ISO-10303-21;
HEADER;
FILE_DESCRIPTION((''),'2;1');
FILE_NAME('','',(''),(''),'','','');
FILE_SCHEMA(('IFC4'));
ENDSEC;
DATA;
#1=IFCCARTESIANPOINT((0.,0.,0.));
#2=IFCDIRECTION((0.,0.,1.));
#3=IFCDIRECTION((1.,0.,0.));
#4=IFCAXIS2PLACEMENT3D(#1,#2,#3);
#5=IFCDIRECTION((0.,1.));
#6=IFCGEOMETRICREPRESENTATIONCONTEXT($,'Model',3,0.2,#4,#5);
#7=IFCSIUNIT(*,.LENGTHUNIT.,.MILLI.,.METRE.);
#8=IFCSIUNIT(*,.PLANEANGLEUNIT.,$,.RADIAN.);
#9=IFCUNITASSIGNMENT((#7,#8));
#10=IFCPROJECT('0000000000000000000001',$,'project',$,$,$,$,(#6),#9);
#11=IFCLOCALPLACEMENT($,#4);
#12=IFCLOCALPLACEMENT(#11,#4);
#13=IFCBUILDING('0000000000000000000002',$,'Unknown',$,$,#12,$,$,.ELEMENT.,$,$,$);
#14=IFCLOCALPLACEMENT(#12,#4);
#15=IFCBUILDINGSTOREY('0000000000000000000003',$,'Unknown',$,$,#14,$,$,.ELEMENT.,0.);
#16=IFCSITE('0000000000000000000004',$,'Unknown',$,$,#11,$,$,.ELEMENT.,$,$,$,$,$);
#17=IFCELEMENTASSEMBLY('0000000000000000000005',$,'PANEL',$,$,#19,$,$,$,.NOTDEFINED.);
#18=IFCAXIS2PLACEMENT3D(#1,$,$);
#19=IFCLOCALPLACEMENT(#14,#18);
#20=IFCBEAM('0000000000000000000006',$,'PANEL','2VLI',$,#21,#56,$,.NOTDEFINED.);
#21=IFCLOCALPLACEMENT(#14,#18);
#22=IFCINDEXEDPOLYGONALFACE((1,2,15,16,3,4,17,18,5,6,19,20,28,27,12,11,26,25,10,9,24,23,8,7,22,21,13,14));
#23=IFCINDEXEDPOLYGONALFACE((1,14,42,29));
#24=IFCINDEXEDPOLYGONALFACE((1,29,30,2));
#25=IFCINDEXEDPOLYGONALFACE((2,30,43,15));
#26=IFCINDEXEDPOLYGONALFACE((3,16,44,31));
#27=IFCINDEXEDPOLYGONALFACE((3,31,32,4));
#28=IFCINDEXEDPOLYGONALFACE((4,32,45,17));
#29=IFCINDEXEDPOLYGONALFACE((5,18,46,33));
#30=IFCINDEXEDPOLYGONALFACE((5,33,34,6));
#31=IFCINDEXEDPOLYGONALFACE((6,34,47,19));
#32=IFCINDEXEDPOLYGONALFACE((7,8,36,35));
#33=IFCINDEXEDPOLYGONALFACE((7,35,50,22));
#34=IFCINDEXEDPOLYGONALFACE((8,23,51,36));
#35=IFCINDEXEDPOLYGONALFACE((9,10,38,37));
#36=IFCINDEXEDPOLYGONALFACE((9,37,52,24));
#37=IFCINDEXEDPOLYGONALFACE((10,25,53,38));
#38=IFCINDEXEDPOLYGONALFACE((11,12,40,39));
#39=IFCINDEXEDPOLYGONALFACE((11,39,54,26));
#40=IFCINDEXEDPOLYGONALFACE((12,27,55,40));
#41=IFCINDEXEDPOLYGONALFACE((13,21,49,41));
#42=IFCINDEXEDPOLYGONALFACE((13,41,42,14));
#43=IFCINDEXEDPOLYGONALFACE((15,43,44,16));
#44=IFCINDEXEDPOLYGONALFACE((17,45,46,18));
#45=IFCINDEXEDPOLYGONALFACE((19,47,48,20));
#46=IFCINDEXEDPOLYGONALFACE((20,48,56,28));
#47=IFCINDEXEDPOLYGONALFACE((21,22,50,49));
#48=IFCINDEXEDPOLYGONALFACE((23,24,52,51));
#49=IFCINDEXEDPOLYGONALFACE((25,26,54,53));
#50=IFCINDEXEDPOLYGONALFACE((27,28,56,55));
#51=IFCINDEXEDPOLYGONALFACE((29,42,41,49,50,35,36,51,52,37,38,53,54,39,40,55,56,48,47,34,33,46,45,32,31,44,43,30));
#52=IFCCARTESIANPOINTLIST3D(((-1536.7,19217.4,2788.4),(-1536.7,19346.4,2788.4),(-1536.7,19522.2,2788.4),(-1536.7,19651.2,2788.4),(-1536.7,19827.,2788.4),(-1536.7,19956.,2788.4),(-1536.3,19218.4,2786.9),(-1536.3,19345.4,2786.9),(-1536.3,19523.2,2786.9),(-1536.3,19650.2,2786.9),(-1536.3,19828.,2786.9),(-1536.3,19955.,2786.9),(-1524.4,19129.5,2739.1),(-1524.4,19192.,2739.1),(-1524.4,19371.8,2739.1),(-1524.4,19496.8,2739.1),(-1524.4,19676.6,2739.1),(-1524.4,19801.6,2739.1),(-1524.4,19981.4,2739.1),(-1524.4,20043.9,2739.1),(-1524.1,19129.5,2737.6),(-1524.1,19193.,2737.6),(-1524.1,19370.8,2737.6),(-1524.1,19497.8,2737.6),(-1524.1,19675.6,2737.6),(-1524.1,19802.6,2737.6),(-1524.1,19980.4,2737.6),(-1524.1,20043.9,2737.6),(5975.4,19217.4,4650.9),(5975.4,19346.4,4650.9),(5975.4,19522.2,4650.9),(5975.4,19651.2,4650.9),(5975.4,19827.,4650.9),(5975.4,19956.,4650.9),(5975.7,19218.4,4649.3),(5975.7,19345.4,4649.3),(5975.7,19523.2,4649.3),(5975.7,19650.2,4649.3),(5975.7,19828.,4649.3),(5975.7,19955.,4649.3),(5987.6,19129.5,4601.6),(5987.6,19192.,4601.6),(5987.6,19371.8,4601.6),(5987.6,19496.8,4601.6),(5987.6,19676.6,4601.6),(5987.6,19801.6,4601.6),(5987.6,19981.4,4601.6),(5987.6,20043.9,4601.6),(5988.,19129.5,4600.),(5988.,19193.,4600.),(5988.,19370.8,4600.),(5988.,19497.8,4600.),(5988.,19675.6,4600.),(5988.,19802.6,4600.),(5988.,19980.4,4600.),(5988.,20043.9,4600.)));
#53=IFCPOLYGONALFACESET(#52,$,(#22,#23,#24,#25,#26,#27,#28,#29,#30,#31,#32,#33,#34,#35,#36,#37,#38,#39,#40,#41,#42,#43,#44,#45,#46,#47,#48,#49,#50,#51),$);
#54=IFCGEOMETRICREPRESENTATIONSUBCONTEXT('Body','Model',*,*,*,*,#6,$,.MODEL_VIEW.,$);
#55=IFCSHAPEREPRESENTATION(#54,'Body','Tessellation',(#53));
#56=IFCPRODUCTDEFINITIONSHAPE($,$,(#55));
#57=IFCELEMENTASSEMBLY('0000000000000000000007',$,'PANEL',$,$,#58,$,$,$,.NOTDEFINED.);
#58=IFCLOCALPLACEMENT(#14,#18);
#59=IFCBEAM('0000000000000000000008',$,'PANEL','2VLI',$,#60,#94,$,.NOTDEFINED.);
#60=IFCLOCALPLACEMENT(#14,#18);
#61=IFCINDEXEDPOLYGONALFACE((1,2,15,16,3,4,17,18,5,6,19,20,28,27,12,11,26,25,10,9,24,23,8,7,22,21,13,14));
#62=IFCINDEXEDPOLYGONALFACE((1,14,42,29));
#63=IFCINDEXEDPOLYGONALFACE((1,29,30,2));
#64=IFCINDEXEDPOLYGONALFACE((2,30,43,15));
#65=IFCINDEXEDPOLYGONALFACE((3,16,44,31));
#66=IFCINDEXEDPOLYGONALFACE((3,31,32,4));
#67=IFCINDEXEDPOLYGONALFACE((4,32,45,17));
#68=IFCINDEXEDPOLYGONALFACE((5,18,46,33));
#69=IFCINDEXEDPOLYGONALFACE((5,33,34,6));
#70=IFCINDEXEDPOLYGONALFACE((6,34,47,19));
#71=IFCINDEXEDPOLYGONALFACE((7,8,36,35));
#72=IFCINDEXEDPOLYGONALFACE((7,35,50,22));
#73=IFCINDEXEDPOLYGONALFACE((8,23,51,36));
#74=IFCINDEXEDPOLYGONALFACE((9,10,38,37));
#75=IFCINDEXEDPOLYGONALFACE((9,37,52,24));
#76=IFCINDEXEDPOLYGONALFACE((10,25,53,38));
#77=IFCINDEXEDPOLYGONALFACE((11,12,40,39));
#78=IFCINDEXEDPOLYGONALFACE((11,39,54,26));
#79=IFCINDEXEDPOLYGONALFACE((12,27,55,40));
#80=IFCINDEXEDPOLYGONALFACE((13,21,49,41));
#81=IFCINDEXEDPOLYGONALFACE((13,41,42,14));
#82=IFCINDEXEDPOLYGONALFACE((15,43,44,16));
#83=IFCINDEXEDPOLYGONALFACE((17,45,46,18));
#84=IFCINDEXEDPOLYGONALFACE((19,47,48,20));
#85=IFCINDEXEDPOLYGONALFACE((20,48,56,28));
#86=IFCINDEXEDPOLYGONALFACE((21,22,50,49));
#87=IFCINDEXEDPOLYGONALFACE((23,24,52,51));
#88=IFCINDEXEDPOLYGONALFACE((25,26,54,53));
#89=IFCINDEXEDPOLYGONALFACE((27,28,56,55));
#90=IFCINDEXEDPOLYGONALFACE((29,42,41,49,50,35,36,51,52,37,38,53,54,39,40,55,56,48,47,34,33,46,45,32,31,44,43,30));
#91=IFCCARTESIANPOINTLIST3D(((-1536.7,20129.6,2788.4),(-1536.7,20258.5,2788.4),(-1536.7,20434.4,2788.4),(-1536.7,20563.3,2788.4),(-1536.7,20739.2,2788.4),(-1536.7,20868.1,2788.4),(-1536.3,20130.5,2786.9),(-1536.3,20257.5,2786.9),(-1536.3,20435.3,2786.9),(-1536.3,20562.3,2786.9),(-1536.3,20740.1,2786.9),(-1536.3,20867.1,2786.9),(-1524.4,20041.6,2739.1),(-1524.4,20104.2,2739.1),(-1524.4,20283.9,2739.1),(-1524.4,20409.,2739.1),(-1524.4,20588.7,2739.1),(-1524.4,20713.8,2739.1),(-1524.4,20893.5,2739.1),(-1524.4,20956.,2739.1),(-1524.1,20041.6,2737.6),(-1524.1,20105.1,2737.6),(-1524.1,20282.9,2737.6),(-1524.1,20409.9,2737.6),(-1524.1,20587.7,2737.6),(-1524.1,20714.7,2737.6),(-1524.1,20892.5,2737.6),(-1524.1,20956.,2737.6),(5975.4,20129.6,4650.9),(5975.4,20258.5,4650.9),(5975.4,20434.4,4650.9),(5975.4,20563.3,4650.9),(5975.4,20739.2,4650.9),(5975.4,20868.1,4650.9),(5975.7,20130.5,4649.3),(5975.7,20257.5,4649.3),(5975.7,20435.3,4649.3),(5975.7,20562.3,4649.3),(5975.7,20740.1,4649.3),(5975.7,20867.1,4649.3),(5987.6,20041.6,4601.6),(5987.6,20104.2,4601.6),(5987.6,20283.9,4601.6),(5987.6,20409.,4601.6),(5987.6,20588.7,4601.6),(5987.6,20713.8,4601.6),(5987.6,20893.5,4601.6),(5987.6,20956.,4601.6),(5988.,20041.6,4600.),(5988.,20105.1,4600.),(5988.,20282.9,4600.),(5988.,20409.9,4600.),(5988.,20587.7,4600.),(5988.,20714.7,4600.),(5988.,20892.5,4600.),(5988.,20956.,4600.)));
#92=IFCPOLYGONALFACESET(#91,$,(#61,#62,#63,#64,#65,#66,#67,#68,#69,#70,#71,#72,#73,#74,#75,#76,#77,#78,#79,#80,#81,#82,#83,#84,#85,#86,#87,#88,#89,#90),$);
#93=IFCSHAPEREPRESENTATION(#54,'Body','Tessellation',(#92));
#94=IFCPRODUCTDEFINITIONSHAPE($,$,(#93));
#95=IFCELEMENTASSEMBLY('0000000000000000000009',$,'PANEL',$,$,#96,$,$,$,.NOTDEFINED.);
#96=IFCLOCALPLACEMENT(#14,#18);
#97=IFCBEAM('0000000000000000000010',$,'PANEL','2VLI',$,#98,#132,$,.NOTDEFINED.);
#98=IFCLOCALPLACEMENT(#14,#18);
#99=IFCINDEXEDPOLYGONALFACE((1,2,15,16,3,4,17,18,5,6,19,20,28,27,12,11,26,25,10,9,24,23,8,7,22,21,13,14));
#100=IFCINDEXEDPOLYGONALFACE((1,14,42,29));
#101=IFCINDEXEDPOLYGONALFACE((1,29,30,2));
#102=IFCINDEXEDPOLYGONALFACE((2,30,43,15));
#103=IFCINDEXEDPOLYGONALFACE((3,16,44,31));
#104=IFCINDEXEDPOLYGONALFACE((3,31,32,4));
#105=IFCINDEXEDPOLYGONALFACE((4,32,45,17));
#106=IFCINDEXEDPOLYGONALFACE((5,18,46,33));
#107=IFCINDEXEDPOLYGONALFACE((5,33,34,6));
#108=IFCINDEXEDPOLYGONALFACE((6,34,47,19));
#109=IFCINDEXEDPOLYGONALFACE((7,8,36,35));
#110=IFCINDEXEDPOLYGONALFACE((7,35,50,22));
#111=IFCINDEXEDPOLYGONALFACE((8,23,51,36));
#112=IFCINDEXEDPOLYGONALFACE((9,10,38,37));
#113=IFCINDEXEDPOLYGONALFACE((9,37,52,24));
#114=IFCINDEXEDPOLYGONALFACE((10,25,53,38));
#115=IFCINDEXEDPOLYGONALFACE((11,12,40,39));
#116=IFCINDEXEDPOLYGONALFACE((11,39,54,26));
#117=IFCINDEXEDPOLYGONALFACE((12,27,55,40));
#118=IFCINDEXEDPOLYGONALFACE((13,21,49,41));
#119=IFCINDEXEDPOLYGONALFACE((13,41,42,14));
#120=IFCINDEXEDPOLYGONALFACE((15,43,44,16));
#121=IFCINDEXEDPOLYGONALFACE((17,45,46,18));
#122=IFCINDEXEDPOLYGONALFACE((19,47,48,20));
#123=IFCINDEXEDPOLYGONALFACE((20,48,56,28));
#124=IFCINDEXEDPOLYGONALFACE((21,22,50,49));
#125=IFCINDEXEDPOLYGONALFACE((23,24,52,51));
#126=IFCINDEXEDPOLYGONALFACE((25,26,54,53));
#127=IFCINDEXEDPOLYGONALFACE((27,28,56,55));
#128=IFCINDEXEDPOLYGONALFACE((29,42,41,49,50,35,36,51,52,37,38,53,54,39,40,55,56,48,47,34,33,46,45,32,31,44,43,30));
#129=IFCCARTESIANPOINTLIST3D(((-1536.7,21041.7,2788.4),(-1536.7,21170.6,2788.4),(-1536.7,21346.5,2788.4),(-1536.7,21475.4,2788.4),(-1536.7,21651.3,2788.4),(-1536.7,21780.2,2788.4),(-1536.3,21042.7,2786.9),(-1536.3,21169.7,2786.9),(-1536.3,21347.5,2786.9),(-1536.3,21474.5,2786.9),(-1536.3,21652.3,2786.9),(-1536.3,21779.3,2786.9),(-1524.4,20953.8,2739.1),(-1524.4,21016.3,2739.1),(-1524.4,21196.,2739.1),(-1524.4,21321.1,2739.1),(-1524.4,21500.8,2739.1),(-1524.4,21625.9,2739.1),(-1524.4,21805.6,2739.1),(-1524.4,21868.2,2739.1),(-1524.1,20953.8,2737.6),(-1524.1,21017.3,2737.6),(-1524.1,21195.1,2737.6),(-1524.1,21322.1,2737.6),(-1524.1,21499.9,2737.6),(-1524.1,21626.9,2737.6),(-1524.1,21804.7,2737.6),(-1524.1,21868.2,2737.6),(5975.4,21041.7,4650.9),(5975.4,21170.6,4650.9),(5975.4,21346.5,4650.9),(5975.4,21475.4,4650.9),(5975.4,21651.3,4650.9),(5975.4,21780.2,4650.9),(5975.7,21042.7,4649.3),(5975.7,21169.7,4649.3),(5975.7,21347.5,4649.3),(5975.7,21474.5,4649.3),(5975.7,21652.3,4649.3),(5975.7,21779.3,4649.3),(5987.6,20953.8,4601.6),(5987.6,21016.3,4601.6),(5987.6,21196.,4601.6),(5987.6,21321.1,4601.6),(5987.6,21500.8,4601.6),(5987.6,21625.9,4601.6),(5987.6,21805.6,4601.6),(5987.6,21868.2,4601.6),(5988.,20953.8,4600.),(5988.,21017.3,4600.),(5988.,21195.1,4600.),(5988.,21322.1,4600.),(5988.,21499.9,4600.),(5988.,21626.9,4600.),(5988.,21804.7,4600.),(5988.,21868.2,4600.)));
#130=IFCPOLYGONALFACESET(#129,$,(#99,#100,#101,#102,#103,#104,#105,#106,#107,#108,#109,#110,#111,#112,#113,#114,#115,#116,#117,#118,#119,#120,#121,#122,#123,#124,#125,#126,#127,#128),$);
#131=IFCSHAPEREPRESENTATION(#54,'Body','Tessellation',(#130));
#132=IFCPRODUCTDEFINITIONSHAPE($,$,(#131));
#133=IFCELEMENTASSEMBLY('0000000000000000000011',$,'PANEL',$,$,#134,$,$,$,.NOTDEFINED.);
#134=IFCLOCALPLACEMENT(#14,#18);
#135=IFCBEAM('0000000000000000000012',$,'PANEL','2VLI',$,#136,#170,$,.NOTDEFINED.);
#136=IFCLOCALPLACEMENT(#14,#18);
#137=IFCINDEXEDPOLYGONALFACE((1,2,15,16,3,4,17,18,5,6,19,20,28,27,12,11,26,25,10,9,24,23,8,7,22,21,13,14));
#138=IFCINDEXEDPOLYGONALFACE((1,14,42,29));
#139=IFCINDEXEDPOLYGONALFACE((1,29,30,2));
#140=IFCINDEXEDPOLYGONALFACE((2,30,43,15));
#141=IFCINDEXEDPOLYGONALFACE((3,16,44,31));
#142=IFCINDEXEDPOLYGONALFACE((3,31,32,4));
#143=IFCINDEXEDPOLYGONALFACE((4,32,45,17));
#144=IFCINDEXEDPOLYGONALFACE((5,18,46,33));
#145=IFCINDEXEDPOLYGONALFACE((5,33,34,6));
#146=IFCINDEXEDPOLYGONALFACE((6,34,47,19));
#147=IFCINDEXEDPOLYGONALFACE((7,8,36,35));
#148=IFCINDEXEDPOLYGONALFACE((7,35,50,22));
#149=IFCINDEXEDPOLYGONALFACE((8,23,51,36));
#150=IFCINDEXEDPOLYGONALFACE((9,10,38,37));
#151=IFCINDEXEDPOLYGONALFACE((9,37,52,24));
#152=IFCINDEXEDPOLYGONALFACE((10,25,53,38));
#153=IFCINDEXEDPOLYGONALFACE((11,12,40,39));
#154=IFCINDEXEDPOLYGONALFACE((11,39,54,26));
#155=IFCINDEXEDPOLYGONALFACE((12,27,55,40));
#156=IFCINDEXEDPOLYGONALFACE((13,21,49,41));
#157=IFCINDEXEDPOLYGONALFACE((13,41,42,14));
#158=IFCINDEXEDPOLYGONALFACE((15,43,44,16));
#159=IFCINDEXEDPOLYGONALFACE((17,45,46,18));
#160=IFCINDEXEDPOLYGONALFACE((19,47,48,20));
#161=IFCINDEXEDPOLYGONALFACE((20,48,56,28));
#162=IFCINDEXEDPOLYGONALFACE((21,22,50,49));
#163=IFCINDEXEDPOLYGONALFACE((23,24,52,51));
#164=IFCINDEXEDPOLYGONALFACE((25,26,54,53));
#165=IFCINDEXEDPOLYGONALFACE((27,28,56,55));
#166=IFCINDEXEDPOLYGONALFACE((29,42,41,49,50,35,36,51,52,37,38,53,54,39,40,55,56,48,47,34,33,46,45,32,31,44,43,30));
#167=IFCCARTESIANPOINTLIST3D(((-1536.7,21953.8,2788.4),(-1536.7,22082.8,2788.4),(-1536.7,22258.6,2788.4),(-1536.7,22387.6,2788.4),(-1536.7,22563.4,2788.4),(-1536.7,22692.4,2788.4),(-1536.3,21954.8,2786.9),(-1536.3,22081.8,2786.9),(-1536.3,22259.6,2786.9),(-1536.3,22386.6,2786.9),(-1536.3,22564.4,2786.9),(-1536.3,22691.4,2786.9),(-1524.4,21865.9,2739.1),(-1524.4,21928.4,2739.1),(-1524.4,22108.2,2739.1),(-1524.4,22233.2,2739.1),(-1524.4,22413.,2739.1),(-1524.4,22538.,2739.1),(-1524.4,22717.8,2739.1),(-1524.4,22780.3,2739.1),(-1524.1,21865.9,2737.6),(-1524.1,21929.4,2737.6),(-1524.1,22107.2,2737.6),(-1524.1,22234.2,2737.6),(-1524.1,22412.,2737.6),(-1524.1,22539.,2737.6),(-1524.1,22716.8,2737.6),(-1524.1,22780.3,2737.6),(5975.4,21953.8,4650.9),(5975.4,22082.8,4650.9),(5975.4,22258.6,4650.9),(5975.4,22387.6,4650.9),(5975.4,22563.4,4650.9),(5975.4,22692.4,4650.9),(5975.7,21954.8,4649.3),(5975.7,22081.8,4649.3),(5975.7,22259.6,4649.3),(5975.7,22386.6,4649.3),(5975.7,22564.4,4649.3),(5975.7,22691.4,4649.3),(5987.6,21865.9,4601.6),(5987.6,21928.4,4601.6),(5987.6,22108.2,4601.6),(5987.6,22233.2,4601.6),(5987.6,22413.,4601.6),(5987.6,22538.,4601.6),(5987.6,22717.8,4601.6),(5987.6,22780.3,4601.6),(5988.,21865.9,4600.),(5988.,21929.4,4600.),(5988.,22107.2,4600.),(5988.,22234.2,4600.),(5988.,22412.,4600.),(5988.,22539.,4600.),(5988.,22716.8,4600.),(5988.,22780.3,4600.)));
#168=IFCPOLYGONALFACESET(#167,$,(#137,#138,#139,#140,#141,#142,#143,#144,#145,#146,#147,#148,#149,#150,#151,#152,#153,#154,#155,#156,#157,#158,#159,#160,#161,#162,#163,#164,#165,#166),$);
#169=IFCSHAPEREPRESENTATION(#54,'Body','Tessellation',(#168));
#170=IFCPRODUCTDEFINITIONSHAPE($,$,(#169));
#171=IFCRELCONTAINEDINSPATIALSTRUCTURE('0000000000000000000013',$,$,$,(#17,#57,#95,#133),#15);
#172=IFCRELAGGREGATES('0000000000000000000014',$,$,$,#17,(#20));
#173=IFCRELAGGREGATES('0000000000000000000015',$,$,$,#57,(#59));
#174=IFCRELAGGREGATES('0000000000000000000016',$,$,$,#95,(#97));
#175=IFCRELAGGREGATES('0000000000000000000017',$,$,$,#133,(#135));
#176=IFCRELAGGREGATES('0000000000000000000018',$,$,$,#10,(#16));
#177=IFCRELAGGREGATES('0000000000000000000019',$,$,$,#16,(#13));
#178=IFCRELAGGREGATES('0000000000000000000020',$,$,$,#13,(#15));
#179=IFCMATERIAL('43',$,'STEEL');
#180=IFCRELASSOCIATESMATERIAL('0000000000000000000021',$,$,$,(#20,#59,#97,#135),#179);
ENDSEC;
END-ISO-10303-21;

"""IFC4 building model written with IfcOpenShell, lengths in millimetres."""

from ifc_helpers import new_model, si_unit, direction, frame, origin_with_axes, place, context, subcontext, project, spatial, line, indexed_curve, outline, extrude, material, element, aggregate, save


model = new_model("IFC4")

# Units and contexts
model_context = context("Model", 3, precision=0.2, world=origin_with_axes(), true_north=direction((0.0, 1.0)))
body_context = subcontext(model_context, "Body", "Model", "MODEL_VIEW")
ifc_project = project(units=[si_unit("LENGTHUNIT", "METRE", prefix="MILLI"), si_unit("PLANEANGLEUNIT", "RADIAN")], contexts=[model_context])

# Site, building, storey
site_placement = place(None, origin_with_axes())
site = spatial("IfcSite", under=ifc_project, at=site_placement, Name="Unknown", CompositionType="ELEMENT")
building_placement = place(site_placement, origin_with_axes())
building = spatial("IfcBuilding", under=site, at=building_placement, Name="Unknown", CompositionType="ELEMENT")
storey_placement = place(building_placement, origin_with_axes())
storey = spatial("IfcBuildingStorey", under=building, at=storey_placement, Name="Unknown", CompositionType="ELEMENT", Elevation=0.0)

# Element assemblies, beams
ifc_material_1 = material(Name="43", Category="STEEL")
assembly_1_placement = place(storey_placement, frame((-1530.4, 19586.7, 2763.0), z_axis=(0.0, -1.0, 0.0), x_axis=(0.970613, 0.0, 0.240648)))
assembly_1 = element("IfcElementAssembly", 1, at=assembly_1_placement, inside=storey, Name="PANEL", PredefinedType="NOTDEFINED")
beam_1_placement = place(assembly_1_placement, origin_with_axes())
beam_1 = element("IfcBeam", 2, at=beam_1_placement, material=ifc_material_1, Name="PANEL", Description="2VLI", PredefinedType="NOTDEFINED", context=body_context, shape_type="SolidModel", body=[
    extrude(outline(indexed_curve([(457.2, -26.2), (457.2, -24.6), (394.7, -24.6), (369.3, 26.2), (240.3, 26.2), (214.9, -24.6), (89.9, -24.6), (64.5, 26.2), (-64.5, 26.2), (-89.9, -24.6), (-214.9, -24.6), (-240.3, 26.2), (-369.3, 26.2), (-394.7, -24.6), (-457.2, -24.6), (-457.2, -26.2), (-393.7, -26.2), (-368.3, 24.6), (-241.3, 24.6), (-215.9, -26.2), (-88.9, -26.2), (-63.5, 24.6), (63.5, 24.6), (88.9, -26.2), (215.9, -26.2), (241.3, 24.6), (368.3, 24.6), (393.7, -26.2)], segments=[line(1, 2, 3, 4, 5, 6, 7, 8, 9, 10, 11, 12, 13, 14, 15, 16, 17, 18, 19, 20, 21, 22, 23, 24, 25, 26, 27, 28, 1)])), frame((0.0, 0.0, 0.0), z_axis=(-1.0, 0.0, 0.0), x_axis=(0.0, 0.0, 1.0)), (0.0, 0.0, -1.0), 7739.5),
])
aggregate(assembly_1, [beam_1])
assembly_2_placement = place(storey_placement, frame((-1530.4, 20498.8, 2763.0), z_axis=(0.0, -1.0, 0.0), x_axis=(0.970613, 0.0, 0.240648)))
assembly_2 = element("IfcElementAssembly", 3, at=assembly_2_placement, inside=storey, Name="PANEL", PredefinedType="NOTDEFINED")
beam_2_placement = place(assembly_2_placement, origin_with_axes())
beam_2 = element("IfcBeam", 4, at=beam_2_placement, material=ifc_material_1, Name="PANEL", Description="2VLI", PredefinedType="NOTDEFINED", context=body_context, shape_type="SolidModel", body=[
    extrude(outline(indexed_curve([(457.2, -26.2), (457.2, -24.6), (394.7, -24.6), (369.3, 26.2), (240.3, 26.2), (214.9, -24.6), (89.9, -24.6), (64.5, 26.2), (-64.5, 26.2), (-89.9, -24.6), (-214.9, -24.6), (-240.3, 26.2), (-369.3, 26.2), (-394.7, -24.6), (-457.2, -24.6), (-457.2, -26.2), (-393.7, -26.2), (-368.3, 24.6), (-241.3, 24.6), (-215.9, -26.2), (-88.9, -26.2), (-63.5, 24.6), (63.5, 24.6), (88.9, -26.2), (215.9, -26.2), (241.3, 24.6), (368.3, 24.6), (393.7, -26.2)], segments=[line(1, 2, 3, 4, 5, 6, 7, 8, 9, 10, 11, 12, 13, 14, 15, 16, 17, 18, 19, 20, 21, 22, 23, 24, 25, 26, 27, 28, 1)])), frame((0.0, 0.0, 0.0), z_axis=(-1.0, 0.0, 0.0), x_axis=(0.0, 0.0, 1.0)), (0.0, 0.0, -1.0), 7739.5),
])
aggregate(assembly_2, [beam_2])
assembly_3_placement = place(storey_placement, frame((-1530.4, 21411.0, 2763.0), z_axis=(0.0, -1.0, 0.0), x_axis=(0.970613, 0.0, 0.240648)))
assembly_3 = element("IfcElementAssembly", 5, at=assembly_3_placement, inside=storey, Name="PANEL", PredefinedType="NOTDEFINED")
beam_3_placement = place(assembly_3_placement, origin_with_axes())
beam_3 = element("IfcBeam", 6, at=beam_3_placement, material=ifc_material_1, Name="PANEL", Description="2VLI", PredefinedType="NOTDEFINED", context=body_context, shape_type="SolidModel", body=[
    extrude(outline(indexed_curve([(457.2, -26.2), (457.2, -24.6), (394.7, -24.6), (369.3, 26.2), (240.3, 26.2), (214.9, -24.6), (89.9, -24.6), (64.5, 26.2), (-64.5, 26.2), (-89.9, -24.6), (-214.9, -24.6), (-240.3, 26.2), (-369.3, 26.2), (-394.7, -24.6), (-457.2, -24.6), (-457.2, -26.2), (-393.7, -26.2), (-368.3, 24.6), (-241.3, 24.6), (-215.9, -26.2), (-88.9, -26.2), (-63.5, 24.6), (63.5, 24.6), (88.9, -26.2), (215.9, -26.2), (241.3, 24.6), (368.3, 24.6), (393.7, -26.2)], segments=[line(1, 2, 3, 4, 5, 6, 7, 8, 9, 10, 11, 12, 13, 14, 15, 16, 17, 18, 19, 20, 21, 22, 23, 24, 25, 26, 27, 28, 1)])), frame((0.0, 0.0, 0.0), z_axis=(-1.0, 0.0, 0.0), x_axis=(0.0, 0.0, 1.0)), (0.0, 0.0, -1.0), 7739.5),
])
aggregate(assembly_3, [beam_3])
assembly_4_placement = place(storey_placement, frame((-1530.4, 22323.1, 2763.0), z_axis=(0.0, -1.0, 0.0), x_axis=(0.970613, 0.0, 0.240648)))
assembly_4 = element("IfcElementAssembly", 7, at=assembly_4_placement, inside=storey, Name="PANEL", PredefinedType="NOTDEFINED")
beam_4_placement = place(assembly_4_placement, origin_with_axes())
beam_4 = element("IfcBeam", 8, at=beam_4_placement, material=ifc_material_1, Name="PANEL", Description="2VLI", PredefinedType="NOTDEFINED", context=body_context, shape_type="SolidModel", body=[
    extrude(outline(indexed_curve([(457.2, -26.2), (457.2, -24.6), (394.7, -24.6), (369.3, 26.2), (240.3, 26.2), (214.9, -24.6), (89.9, -24.6), (64.5, 26.2), (-64.5, 26.2), (-89.9, -24.6), (-214.9, -24.6), (-240.3, 26.2), (-369.3, 26.2), (-394.7, -24.6), (-457.2, -24.6), (-457.2, -26.2), (-393.7, -26.2), (-368.3, 24.6), (-241.3, 24.6), (-215.9, -26.2), (-88.9, -26.2), (-63.5, 24.6), (63.5, 24.6), (88.9, -26.2), (215.9, -26.2), (241.3, 24.6), (368.3, 24.6), (393.7, -26.2)], segments=[line(1, 2, 3, 4, 5, 6, 7, 8, 9, 10, 11, 12, 13, 14, 15, 16, 17, 18, 19, 20, 21, 22, 23, 24, 25, 26, 27, 28, 1)])), frame((0.0, 0.0, 0.0), z_axis=(-1.0, 0.0, 0.0), x_axis=(0.0, 0.0, 1.0)), (0.0, 0.0, -1.0), 7739.5),
])
aggregate(assembly_4, [beam_4])

save(model, "model.ifc")
